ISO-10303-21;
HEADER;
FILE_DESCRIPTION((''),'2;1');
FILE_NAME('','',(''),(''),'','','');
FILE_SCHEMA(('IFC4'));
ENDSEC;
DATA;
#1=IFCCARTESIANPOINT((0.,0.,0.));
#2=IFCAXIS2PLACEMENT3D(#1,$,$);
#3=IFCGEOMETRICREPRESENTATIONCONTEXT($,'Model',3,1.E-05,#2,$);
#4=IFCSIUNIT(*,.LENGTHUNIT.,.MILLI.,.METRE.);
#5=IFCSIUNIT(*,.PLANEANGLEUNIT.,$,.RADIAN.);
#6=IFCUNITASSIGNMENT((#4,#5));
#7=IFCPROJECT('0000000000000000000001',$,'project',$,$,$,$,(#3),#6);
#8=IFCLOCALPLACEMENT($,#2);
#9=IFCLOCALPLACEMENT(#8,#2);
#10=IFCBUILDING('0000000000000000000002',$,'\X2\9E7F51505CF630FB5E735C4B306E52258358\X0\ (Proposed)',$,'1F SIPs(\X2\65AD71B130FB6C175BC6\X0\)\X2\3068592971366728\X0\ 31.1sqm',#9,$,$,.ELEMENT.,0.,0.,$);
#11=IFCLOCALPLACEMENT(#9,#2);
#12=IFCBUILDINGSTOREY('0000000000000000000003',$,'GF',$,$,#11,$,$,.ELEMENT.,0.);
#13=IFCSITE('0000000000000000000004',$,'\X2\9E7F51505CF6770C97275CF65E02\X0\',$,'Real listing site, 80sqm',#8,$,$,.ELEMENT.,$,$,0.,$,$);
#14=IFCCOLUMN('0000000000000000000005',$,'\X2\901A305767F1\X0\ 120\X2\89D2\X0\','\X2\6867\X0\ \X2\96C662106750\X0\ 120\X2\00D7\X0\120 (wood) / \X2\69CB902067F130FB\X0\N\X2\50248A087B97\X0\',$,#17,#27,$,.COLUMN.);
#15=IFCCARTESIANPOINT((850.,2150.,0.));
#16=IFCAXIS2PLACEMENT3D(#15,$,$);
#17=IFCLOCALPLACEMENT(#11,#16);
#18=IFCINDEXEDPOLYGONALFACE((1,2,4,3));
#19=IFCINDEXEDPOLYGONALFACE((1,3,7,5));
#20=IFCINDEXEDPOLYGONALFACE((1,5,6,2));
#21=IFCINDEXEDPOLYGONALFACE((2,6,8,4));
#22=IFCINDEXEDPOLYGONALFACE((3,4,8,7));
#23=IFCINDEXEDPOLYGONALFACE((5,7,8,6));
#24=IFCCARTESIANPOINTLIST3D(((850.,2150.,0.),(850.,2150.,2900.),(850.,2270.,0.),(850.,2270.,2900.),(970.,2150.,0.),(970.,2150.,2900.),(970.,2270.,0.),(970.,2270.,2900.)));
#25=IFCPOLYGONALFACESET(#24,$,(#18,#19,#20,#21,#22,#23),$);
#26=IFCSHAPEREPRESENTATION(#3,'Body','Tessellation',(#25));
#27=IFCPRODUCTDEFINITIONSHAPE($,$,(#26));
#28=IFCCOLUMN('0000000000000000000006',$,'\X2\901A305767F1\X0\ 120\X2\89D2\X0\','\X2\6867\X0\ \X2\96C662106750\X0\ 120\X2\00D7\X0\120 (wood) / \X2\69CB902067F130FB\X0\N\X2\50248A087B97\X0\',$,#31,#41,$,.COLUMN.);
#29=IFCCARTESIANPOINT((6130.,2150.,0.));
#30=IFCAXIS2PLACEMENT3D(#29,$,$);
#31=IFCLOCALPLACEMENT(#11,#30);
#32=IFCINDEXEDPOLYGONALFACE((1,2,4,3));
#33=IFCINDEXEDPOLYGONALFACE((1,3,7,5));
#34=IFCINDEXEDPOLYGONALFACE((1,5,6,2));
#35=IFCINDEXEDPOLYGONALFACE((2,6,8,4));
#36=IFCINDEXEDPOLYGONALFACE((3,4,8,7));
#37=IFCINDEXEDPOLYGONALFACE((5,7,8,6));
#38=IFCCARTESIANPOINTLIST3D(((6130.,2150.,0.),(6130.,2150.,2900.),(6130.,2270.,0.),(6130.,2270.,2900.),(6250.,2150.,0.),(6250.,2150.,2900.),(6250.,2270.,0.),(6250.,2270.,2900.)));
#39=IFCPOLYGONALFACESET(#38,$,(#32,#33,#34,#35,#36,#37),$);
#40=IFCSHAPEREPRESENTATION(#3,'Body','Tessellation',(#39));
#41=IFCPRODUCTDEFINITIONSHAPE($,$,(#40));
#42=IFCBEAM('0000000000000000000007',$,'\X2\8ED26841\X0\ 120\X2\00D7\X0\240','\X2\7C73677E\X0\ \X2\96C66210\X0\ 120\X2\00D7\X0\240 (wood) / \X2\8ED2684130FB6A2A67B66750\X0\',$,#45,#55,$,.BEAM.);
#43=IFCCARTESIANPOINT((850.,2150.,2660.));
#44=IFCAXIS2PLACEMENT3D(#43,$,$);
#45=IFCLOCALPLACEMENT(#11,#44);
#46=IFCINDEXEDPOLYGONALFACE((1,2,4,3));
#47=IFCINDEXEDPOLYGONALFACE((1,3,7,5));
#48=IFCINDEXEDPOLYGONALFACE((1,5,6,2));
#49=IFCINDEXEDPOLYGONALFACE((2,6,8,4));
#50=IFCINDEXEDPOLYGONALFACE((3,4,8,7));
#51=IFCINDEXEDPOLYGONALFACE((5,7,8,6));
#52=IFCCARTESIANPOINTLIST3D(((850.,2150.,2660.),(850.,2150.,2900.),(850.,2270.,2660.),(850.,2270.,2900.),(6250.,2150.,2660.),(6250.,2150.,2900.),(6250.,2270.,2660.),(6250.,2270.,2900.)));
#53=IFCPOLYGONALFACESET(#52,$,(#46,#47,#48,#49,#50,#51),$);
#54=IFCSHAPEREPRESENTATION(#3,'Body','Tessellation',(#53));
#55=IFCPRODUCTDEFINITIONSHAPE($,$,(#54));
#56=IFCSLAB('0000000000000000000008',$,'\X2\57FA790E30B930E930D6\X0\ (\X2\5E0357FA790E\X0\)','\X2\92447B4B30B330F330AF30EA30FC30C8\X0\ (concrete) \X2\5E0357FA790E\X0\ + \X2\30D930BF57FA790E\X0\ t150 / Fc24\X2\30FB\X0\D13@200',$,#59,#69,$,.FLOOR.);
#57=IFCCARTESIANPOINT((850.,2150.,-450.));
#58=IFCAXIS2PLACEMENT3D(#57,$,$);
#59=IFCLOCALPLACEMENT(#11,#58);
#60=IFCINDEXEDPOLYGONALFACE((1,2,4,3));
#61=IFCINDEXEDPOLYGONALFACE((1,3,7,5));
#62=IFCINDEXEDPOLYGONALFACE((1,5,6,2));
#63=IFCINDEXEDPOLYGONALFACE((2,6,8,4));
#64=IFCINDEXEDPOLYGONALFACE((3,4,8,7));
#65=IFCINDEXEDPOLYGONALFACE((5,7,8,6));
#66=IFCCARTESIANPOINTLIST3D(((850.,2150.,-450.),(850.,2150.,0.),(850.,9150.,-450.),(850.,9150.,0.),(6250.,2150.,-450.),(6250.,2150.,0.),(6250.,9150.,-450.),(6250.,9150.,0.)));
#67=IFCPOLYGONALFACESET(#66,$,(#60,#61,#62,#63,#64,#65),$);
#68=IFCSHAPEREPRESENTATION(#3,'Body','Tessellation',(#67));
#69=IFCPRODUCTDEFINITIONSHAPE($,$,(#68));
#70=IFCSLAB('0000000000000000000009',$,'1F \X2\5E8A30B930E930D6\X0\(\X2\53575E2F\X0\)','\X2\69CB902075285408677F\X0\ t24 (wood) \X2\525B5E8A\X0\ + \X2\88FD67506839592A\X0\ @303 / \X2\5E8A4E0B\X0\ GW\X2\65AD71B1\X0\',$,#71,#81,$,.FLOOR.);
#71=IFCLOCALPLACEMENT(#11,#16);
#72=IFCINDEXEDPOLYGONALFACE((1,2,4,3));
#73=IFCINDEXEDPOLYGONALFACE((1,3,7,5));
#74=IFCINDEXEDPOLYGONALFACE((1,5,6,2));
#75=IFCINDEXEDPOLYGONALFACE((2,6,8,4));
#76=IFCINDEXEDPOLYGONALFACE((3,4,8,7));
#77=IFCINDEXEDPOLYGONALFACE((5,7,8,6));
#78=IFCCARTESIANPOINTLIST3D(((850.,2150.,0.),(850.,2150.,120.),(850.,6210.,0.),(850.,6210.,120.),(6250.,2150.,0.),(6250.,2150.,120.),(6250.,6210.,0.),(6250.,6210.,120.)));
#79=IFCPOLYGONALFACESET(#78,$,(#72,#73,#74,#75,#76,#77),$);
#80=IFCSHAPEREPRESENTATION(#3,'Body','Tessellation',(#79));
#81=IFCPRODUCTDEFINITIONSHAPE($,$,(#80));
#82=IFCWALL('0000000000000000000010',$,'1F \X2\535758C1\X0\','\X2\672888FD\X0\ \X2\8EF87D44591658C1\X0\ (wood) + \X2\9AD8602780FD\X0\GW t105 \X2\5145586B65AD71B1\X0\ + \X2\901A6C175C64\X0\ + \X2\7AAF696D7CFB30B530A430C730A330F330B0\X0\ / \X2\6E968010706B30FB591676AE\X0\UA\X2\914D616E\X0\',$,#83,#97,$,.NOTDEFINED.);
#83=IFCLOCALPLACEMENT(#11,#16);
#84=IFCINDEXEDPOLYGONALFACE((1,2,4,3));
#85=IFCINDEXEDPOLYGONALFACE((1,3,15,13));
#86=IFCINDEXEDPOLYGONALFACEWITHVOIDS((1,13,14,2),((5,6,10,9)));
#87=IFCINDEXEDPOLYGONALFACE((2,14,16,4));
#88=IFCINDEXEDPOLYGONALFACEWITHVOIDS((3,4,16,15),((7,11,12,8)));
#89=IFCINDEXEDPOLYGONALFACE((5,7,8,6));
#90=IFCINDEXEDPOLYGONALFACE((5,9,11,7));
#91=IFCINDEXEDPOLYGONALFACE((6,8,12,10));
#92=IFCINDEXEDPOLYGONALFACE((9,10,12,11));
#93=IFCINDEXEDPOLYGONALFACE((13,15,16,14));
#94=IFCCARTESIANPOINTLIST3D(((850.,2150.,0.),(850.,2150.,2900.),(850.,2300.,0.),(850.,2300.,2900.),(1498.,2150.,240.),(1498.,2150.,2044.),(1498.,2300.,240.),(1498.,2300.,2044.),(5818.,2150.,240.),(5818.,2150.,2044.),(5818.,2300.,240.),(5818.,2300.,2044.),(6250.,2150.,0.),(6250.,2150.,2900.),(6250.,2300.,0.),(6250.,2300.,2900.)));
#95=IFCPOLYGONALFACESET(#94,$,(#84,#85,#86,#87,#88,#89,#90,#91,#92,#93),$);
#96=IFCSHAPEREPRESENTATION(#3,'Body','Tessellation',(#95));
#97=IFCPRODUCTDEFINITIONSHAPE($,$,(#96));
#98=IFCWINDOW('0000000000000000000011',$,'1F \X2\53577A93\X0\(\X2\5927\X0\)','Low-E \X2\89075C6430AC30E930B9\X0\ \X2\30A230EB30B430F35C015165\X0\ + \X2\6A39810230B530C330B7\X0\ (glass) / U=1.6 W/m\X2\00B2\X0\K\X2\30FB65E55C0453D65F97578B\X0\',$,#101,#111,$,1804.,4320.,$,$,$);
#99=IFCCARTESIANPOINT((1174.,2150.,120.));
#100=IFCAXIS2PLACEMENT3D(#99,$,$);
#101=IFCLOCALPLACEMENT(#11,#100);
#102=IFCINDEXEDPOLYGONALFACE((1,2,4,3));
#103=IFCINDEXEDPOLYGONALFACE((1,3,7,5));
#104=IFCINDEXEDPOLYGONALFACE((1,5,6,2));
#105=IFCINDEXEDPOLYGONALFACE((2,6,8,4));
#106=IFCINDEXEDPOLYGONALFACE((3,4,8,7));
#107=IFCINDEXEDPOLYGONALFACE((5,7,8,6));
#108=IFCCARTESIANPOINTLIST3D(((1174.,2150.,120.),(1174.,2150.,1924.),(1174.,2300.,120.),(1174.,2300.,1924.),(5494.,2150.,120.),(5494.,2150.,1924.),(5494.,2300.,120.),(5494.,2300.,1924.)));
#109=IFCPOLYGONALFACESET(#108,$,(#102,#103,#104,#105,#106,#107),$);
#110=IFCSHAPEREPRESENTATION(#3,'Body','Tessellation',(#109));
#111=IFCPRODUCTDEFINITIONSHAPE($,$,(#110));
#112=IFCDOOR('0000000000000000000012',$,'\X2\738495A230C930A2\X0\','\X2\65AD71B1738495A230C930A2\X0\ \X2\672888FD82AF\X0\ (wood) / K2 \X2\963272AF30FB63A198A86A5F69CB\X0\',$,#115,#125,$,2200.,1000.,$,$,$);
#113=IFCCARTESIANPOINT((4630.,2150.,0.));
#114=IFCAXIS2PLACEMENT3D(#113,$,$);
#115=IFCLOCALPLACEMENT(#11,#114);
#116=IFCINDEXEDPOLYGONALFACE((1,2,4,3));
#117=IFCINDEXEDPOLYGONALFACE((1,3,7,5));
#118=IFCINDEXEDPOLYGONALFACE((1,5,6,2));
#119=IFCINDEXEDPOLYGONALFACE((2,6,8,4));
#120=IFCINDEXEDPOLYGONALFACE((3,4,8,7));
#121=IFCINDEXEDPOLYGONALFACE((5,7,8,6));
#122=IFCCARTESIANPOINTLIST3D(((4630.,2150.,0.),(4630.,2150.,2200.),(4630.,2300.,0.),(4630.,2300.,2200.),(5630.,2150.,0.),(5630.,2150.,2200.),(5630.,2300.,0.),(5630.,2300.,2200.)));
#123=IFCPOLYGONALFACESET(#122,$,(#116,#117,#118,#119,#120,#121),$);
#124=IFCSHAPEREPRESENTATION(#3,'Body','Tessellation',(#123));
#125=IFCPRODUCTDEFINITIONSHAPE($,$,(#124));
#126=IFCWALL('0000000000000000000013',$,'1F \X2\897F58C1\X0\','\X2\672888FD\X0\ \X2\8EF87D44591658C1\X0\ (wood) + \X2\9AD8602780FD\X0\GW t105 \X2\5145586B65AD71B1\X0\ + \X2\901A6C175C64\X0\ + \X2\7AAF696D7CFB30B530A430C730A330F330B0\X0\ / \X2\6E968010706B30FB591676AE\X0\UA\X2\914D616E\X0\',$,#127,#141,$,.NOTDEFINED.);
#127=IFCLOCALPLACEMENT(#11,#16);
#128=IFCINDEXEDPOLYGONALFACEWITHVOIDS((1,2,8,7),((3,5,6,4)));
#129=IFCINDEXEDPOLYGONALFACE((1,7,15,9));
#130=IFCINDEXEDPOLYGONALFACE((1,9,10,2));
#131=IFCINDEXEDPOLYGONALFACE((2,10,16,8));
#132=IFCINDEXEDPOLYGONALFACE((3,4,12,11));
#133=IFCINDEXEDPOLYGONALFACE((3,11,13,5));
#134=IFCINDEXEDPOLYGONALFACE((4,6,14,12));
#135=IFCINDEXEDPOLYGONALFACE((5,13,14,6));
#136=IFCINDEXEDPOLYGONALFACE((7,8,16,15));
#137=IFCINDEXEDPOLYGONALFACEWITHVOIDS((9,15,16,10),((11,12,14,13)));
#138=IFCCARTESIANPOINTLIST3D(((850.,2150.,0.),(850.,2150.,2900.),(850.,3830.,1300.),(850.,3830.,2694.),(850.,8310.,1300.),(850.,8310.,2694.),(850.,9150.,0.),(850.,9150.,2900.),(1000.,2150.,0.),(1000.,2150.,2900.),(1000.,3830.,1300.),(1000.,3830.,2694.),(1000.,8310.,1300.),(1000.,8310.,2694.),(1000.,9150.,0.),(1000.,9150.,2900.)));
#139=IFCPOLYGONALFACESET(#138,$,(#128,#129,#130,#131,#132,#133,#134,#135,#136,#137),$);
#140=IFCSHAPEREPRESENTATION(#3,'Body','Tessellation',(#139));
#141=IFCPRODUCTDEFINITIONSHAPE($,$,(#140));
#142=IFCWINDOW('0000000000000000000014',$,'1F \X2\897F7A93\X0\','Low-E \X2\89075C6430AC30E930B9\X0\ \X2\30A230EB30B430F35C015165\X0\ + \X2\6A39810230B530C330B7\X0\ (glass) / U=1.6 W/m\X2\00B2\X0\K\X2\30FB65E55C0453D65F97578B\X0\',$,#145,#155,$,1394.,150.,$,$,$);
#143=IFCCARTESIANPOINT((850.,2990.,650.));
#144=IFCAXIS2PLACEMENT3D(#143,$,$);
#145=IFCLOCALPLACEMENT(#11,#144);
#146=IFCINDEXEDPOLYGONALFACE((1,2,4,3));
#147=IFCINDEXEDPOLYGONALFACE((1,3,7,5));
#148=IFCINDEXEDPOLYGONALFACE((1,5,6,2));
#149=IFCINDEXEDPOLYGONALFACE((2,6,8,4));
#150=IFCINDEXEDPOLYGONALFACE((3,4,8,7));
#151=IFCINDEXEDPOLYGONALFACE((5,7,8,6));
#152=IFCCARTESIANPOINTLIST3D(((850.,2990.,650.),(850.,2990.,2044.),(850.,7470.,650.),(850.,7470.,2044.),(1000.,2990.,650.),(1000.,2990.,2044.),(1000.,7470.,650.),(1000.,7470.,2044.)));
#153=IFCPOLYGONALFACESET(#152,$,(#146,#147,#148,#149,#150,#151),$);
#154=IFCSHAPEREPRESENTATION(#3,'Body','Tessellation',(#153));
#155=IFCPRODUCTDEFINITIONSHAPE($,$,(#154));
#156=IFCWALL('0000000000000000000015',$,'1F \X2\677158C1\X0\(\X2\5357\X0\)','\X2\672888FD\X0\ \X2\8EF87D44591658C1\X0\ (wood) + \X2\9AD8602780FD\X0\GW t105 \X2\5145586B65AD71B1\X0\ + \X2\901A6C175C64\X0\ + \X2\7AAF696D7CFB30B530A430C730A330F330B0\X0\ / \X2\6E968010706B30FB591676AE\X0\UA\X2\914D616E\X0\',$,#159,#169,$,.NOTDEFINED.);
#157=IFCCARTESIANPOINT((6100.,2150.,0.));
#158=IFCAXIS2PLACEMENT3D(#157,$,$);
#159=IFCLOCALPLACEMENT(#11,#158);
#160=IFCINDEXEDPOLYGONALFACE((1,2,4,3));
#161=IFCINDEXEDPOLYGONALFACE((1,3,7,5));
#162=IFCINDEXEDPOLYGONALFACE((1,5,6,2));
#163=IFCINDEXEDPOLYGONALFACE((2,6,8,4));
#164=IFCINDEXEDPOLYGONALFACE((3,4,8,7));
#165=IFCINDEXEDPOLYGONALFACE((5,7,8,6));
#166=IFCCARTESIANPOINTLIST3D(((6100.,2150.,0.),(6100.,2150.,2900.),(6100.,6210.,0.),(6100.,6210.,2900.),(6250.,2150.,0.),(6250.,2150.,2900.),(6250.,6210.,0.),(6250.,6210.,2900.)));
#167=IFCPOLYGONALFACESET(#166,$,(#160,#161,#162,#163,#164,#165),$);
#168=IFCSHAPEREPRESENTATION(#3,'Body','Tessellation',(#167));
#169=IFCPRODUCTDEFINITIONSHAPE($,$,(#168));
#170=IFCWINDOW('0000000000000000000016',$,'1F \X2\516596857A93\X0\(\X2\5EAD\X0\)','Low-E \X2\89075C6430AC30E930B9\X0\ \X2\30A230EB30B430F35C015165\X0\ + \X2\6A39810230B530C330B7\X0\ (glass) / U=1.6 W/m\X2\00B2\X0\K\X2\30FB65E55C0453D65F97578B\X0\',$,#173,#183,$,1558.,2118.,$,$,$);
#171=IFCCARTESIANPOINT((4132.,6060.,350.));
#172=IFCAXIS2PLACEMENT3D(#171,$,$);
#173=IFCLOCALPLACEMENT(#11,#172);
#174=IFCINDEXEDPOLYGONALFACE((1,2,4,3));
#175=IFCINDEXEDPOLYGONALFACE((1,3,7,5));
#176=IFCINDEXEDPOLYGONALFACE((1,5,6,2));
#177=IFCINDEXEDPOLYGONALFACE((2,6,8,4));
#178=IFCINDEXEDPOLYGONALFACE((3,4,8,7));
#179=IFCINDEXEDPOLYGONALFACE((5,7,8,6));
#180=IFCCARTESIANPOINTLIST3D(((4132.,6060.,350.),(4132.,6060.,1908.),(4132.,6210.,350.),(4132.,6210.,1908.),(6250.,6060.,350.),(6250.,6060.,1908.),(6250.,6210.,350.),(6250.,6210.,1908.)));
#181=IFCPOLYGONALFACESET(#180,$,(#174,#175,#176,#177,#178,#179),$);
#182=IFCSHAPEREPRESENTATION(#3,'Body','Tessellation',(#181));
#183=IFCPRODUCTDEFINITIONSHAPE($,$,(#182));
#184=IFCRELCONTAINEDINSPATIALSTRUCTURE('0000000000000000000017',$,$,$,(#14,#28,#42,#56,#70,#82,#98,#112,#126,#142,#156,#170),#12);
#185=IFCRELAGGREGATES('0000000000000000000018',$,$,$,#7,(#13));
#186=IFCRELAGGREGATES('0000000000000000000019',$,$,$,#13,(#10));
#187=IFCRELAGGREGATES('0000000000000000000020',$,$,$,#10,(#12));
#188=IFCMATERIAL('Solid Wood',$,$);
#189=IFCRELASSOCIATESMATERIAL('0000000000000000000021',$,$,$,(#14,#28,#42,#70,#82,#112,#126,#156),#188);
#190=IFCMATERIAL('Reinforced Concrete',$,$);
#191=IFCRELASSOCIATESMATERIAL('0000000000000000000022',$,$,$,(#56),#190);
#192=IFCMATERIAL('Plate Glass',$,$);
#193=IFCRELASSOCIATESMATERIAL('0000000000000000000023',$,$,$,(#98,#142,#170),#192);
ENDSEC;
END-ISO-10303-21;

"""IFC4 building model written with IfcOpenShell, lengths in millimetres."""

from ifc_helpers import new_model, si_unit, frame, frame_2d, origin, place, context, project, spatial, rectangle, extrude, material, element, fill, save


model = new_model("IFC4")

# Units and contexts
model_context = context("Model", 3, precision=1e-05, world=origin())
ifc_project = project(units=[si_unit("LENGTHUNIT", "METRE", prefix="MILLI"), si_unit("PLANEANGLEUNIT", "RADIAN")], contexts=[model_context])

# Site, building, storey
site_placement = place(None, origin())
site = spatial("IfcSite", under=ifc_project, at=site_placement, Name="鹿児島県霧島市", ObjectType="Real listing site, 80sqm", CompositionType="ELEMENT", RefElevation=0.0)
building_placement = place(site_placement, origin())
building = spatial("IfcBuilding", under=site, at=building_placement, Name="鹿児島・平屋の別荘 (Proposed)", ObjectType="1F SIPs(断熱・気密)と天然木 31.1sqm", CompositionType="ELEMENT", ElevationOfRefHeight=0.0, ElevationOfTerrain=0.0)
storey_placement = place(building_placement, origin())
storey = spatial("IfcBuildingStorey", under=building, at=storey_placement, Name="GF", CompositionType="ELEMENT", Elevation=0.0)

# Columns
ifc_material_1 = material(Name="Solid Wood")
column_1_placement = place(storey_placement, frame((850.0, 2150.0, 0.0)))
element("IfcColumn", 1, at=column_1_placement, inside=storey, material=ifc_material_1, Name="通し柱 120角", Description="桧 集成材 120×120 (wood) / 構造柱・N値計算", PredefinedType="COLUMN", context=model_context, shape_type="SweptSolid", body=[
    extrude(rectangle(XDim=120.0, YDim=120.0, at=frame_2d((60.0, 60.0))), frame((850.0, 2150.0, 0.0)), (0.0, 0.0, 1.0), 2900.0),
])
column_2_placement = place(storey_placement, frame((6130.0, 2150.0, 0.0)))
element("IfcColumn", 2, at=column_2_placement, inside=storey, material=ifc_material_1, Name="通し柱 120角", Description="桧 集成材 120×120 (wood) / 構造柱・N値計算", PredefinedType="COLUMN", context=model_context, shape_type="SweptSolid", body=[
    extrude(rectangle(XDim=120.0, YDim=120.0, at=frame_2d((60.0, 60.0))), frame((6130.0, 2150.0, 0.0)), (0.0, 0.0, 1.0), 2900.0),
])

# Beam
beam_1_placement = place(storey_placement, frame((850.0, 2150.0, 2660.0)))
element("IfcBeam", 3, at=beam_1_placement, inside=storey, material=ifc_material_1, Name="軒桁 120×240", Description="米松 集成 120×240 (wood) / 軒桁・横架材", PredefinedType="BEAM", context=model_context, shape_type="SweptSolid", body=[
    extrude(rectangle(XDim=5400.0, YDim=120.0, at=frame_2d((2700.0, 60.0))), frame((850.0, 2150.0, 2660.0)), (0.0, 0.0, 1.0), 240.0),
])

# Slabs
ifc_material_2 = material(Name="Reinforced Concrete")
slab_1_placement = place(storey_placement, frame((850.0, 2150.0, -450.0)))
element("IfcSlab", 4, at=slab_1_placement, inside=storey, material=ifc_material_2, Name="基礎スラブ (布基礎)", Description="鉄筋コンクリート (concrete) 布基礎 + ベタ基礎 t150 / Fc24・D13@200", PredefinedType="FLOOR", context=model_context, shape_type="SweptSolid", body=[
    extrude(rectangle(XDim=5400.0, YDim=7000.0, at=frame_2d((2700.0, 3500.0))), frame((850.0, 2150.0, -450.0)), (0.0, 0.0, 1.0), 450.0),
])
slab_2_placement = place(storey_placement, frame((850.0, 2150.0, 0.0)))
element("IfcSlab", 5, at=slab_2_placement, inside=storey, material=ifc_material_1, Name="1F 床スラブ(南帯)", Description="構造用合板 t24 (wood) 剛床 + 製材根太 @303 / 床下 GW断熱", PredefinedType="FLOOR", context=model_context, shape_type="SweptSolid", body=[
    extrude(rectangle(XDim=5400.0, YDim=4060.0, at=frame_2d((2700.0, 2030.0))), frame((850.0, 2150.0, 0.0)), (0.0, 0.0, 1.0), 120.0),
])

# Wall, openings, window, door
wall_1_placement = place(storey_placement, frame((850.0, 2150.0, 0.0)))
wall_1 = element("IfcWall", 6, at=wall_1_placement, inside=storey, material=ifc_material_1, Name="1F 南壁", Description="木製 軸組外壁 (wood) + 高性能GW t105 充填断熱 + 通気層 + 窯業系サイディング / 準耐火・外皮UA配慮", PredefinedType="NOTDEFINED", context=model_context, shape_type="SweptSolid", body=[
    extrude(rectangle(XDim=5400.0, YDim=150.0, at=frame_2d((2700.0, 75.0))), frame((850.0, 2150.0, 0.0)), (0.0, 0.0, 1.0), 2900.0),
])
opening_1_placement = place(storey_placement, frame((1174.0, 2150.0, 120.0)))
opening_1 = element("IfcOpeningElement", 7, at=opening_1_placement, cuts=wall_1, PredefinedType="NOTDEFINED", context=model_context, shape_type="SweptSolid", body=[
    extrude(rectangle(XDim=4320.0, YDim=150.0, at=frame_2d((2160.0, 75.0))), frame((1174.0, 2150.0, 120.0)), (0.0, 0.0, 1.0), 1804.0),
])
opening_2_placement = place(storey_placement, frame((4630.0, 2150.0, 0.0)))
opening_2 = element("IfcOpeningElement", 8, at=opening_2_placement, cuts=wall_1, PredefinedType="NOTDEFINED", context=model_context, shape_type="SweptSolid", body=[
    extrude(rectangle(XDim=1000.0, YDim=150.0, at=frame_2d((500.0, 75.0))), frame((4630.0, 2150.0, 0.0)), (0.0, 0.0, 1.0), 2200.0),
])
ifc_material_3 = material(Name="Plate Glass")
window_1_placement = place(storey_placement, frame((1174.0, 2150.0, 120.0)))
window_1 = element("IfcWindow", 9, at=window_1_placement, inside=storey, material=ifc_material_3, Name="1F 南窓(大)", Description="Low-E 複層ガラス アルゴン封入 + 樹脂サッシ (glass) / U=1.6 W/m²K・日射取得型", OverallHeight=1804.0, OverallWidth=4320.0, context=model_context, shape_type="SweptSolid", body=[
    extrude(rectangle(XDim=4320.0, YDim=150.0, at=frame_2d((2160.0, 75.0))), frame((1174.0, 2150.0, 120.0)), (0.0, 0.0, 1.0), 1804.0),
])
fill(opening_1, window_1)
door_1_placement = place(storey_placement, frame((4630.0, 2150.0, 0.0)))
door_1 = element("IfcDoor", 10, at=door_1_placement, inside=storey, material=ifc_material_1, Name="玄関ドア", Description="断熱玄関ドア 木製芯 (wood) / K2 防犯・採風機構", OverallHeight=2200.0, OverallWidth=1000.0, context=model_context, shape_type="SweptSolid", body=[
    extrude(rectangle(XDim=1000.0, YDim=150.0, at=frame_2d((500.0, 75.0))), frame((4630.0, 2150.0, 0.0)), (0.0, 0.0, 1.0), 2200.0),
])
fill(opening_2, door_1)

# Walls, openings, windows
wall_2_placement = place(storey_placement, frame((850.0, 2150.0, 0.0)))
wall_2 = element("IfcWall", 11, at=wall_2_placement, inside=storey, material=ifc_material_1, Name="1F 西壁", Description="木製 軸組外壁 (wood) + 高性能GW t105 充填断熱 + 通気層 + 窯業系サイディング / 準耐火・外皮UA配慮", PredefinedType="NOTDEFINED", context=model_context, shape_type="SweptSolid", body=[
    extrude(rectangle(XDim=150.0, YDim=7000.0, at=frame_2d((75.0, 3500.0))), frame((850.0, 2150.0, 0.0)), (0.0, 0.0, 1.0), 2900.0),
])
opening_3_placement = place(storey_placement, frame((850.0, 2990.0, 650.0)))
opening_3 = element("IfcOpeningElement", 12, at=opening_3_placement, cuts=wall_2, PredefinedType="NOTDEFINED", context=model_context, shape_type="SweptSolid", body=[
    extrude(rectangle(XDim=150.0, YDim=4480.0, at=frame_2d((75.0, 2240.0))), frame((850.0, 2990.0, 650.0)), (0.0, 0.0, 1.0), 1394.0),
])
window_2_placement = place(storey_placement, frame((850.0, 2990.0, 650.0)))
window_2 = element("IfcWindow", 13, at=window_2_placement, inside=storey, material=ifc_material_3, Name="1F 西窓", Description="Low-E 複層ガラス アルゴン封入 + 樹脂サッシ (glass) / U=1.6 W/m²K・日射取得型", OverallHeight=1394.0, OverallWidth=150.0, context=model_context, shape_type="SweptSolid", body=[
    extrude(rectangle(XDim=150.0, YDim=4480.0, at=frame_2d((75.0, 2240.0))), frame((850.0, 2990.0, 650.0)), (0.0, 0.0, 1.0), 1394.0),
])
fill(opening_3, window_2)
wall_3_placement = place(storey_placement, frame((6100.0, 2150.0, 0.0)))
wall_3 = element("IfcWall", 14, at=wall_3_placement, inside=storey, material=ifc_material_1, Name="1F 東壁(南)", Description="木製 軸組外壁 (wood) + 高性能GW t105 充填断熱 + 通気層 + 窯業系サイディング / 準耐火・外皮UA配慮", PredefinedType="NOTDEFINED", context=model_context, shape_type="SweptSolid", body=[
    extrude(rectangle(XDim=150.0, YDim=4060.0, at=frame_2d((75.0, 2030.0))), frame((6100.0, 2150.0, 0.0)), (0.0, 0.0, 1.0), 2900.0),
])
opening_4_placement = place(storey_placement, frame((4132.0, 6060.0, 350.0)))
opening_4 = element("IfcOpeningElement", 15, at=opening_4_placement, cuts=wall_3, PredefinedType="NOTDEFINED", context=model_context, shape_type="SweptSolid", body=[
    extrude(rectangle(XDim=2118.0, YDim=150.0, at=frame_2d((1059.0, 75.0))), frame((4132.0, 6060.0, 350.0)), (0.0, 0.0, 1.0), 1558.0),
])
window_3_placement = place(storey_placement, frame((4132.0, 6060.0, 350.0)))
window_3 = element("IfcWindow", 16, at=window_3_placement, inside=storey, material=ifc_material_3, Name="1F 入隅窓(庭)", Description="Low-E 複層ガラス アルゴン封入 + 樹脂サッシ (glass) / U=1.6 W/m²K・日射取得型", OverallHeight=1558.0, OverallWidth=2118.0, context=model_context, shape_type="SweptSolid", body=[
    extrude(rectangle(XDim=2118.0, YDim=150.0, at=frame_2d((1059.0, 75.0))), frame((4132.0, 6060.0, 350.0)), (0.0, 0.0, 1.0), 1558.0),
])
fill(opening_4, window_3)

save(model, "model.ifc")
